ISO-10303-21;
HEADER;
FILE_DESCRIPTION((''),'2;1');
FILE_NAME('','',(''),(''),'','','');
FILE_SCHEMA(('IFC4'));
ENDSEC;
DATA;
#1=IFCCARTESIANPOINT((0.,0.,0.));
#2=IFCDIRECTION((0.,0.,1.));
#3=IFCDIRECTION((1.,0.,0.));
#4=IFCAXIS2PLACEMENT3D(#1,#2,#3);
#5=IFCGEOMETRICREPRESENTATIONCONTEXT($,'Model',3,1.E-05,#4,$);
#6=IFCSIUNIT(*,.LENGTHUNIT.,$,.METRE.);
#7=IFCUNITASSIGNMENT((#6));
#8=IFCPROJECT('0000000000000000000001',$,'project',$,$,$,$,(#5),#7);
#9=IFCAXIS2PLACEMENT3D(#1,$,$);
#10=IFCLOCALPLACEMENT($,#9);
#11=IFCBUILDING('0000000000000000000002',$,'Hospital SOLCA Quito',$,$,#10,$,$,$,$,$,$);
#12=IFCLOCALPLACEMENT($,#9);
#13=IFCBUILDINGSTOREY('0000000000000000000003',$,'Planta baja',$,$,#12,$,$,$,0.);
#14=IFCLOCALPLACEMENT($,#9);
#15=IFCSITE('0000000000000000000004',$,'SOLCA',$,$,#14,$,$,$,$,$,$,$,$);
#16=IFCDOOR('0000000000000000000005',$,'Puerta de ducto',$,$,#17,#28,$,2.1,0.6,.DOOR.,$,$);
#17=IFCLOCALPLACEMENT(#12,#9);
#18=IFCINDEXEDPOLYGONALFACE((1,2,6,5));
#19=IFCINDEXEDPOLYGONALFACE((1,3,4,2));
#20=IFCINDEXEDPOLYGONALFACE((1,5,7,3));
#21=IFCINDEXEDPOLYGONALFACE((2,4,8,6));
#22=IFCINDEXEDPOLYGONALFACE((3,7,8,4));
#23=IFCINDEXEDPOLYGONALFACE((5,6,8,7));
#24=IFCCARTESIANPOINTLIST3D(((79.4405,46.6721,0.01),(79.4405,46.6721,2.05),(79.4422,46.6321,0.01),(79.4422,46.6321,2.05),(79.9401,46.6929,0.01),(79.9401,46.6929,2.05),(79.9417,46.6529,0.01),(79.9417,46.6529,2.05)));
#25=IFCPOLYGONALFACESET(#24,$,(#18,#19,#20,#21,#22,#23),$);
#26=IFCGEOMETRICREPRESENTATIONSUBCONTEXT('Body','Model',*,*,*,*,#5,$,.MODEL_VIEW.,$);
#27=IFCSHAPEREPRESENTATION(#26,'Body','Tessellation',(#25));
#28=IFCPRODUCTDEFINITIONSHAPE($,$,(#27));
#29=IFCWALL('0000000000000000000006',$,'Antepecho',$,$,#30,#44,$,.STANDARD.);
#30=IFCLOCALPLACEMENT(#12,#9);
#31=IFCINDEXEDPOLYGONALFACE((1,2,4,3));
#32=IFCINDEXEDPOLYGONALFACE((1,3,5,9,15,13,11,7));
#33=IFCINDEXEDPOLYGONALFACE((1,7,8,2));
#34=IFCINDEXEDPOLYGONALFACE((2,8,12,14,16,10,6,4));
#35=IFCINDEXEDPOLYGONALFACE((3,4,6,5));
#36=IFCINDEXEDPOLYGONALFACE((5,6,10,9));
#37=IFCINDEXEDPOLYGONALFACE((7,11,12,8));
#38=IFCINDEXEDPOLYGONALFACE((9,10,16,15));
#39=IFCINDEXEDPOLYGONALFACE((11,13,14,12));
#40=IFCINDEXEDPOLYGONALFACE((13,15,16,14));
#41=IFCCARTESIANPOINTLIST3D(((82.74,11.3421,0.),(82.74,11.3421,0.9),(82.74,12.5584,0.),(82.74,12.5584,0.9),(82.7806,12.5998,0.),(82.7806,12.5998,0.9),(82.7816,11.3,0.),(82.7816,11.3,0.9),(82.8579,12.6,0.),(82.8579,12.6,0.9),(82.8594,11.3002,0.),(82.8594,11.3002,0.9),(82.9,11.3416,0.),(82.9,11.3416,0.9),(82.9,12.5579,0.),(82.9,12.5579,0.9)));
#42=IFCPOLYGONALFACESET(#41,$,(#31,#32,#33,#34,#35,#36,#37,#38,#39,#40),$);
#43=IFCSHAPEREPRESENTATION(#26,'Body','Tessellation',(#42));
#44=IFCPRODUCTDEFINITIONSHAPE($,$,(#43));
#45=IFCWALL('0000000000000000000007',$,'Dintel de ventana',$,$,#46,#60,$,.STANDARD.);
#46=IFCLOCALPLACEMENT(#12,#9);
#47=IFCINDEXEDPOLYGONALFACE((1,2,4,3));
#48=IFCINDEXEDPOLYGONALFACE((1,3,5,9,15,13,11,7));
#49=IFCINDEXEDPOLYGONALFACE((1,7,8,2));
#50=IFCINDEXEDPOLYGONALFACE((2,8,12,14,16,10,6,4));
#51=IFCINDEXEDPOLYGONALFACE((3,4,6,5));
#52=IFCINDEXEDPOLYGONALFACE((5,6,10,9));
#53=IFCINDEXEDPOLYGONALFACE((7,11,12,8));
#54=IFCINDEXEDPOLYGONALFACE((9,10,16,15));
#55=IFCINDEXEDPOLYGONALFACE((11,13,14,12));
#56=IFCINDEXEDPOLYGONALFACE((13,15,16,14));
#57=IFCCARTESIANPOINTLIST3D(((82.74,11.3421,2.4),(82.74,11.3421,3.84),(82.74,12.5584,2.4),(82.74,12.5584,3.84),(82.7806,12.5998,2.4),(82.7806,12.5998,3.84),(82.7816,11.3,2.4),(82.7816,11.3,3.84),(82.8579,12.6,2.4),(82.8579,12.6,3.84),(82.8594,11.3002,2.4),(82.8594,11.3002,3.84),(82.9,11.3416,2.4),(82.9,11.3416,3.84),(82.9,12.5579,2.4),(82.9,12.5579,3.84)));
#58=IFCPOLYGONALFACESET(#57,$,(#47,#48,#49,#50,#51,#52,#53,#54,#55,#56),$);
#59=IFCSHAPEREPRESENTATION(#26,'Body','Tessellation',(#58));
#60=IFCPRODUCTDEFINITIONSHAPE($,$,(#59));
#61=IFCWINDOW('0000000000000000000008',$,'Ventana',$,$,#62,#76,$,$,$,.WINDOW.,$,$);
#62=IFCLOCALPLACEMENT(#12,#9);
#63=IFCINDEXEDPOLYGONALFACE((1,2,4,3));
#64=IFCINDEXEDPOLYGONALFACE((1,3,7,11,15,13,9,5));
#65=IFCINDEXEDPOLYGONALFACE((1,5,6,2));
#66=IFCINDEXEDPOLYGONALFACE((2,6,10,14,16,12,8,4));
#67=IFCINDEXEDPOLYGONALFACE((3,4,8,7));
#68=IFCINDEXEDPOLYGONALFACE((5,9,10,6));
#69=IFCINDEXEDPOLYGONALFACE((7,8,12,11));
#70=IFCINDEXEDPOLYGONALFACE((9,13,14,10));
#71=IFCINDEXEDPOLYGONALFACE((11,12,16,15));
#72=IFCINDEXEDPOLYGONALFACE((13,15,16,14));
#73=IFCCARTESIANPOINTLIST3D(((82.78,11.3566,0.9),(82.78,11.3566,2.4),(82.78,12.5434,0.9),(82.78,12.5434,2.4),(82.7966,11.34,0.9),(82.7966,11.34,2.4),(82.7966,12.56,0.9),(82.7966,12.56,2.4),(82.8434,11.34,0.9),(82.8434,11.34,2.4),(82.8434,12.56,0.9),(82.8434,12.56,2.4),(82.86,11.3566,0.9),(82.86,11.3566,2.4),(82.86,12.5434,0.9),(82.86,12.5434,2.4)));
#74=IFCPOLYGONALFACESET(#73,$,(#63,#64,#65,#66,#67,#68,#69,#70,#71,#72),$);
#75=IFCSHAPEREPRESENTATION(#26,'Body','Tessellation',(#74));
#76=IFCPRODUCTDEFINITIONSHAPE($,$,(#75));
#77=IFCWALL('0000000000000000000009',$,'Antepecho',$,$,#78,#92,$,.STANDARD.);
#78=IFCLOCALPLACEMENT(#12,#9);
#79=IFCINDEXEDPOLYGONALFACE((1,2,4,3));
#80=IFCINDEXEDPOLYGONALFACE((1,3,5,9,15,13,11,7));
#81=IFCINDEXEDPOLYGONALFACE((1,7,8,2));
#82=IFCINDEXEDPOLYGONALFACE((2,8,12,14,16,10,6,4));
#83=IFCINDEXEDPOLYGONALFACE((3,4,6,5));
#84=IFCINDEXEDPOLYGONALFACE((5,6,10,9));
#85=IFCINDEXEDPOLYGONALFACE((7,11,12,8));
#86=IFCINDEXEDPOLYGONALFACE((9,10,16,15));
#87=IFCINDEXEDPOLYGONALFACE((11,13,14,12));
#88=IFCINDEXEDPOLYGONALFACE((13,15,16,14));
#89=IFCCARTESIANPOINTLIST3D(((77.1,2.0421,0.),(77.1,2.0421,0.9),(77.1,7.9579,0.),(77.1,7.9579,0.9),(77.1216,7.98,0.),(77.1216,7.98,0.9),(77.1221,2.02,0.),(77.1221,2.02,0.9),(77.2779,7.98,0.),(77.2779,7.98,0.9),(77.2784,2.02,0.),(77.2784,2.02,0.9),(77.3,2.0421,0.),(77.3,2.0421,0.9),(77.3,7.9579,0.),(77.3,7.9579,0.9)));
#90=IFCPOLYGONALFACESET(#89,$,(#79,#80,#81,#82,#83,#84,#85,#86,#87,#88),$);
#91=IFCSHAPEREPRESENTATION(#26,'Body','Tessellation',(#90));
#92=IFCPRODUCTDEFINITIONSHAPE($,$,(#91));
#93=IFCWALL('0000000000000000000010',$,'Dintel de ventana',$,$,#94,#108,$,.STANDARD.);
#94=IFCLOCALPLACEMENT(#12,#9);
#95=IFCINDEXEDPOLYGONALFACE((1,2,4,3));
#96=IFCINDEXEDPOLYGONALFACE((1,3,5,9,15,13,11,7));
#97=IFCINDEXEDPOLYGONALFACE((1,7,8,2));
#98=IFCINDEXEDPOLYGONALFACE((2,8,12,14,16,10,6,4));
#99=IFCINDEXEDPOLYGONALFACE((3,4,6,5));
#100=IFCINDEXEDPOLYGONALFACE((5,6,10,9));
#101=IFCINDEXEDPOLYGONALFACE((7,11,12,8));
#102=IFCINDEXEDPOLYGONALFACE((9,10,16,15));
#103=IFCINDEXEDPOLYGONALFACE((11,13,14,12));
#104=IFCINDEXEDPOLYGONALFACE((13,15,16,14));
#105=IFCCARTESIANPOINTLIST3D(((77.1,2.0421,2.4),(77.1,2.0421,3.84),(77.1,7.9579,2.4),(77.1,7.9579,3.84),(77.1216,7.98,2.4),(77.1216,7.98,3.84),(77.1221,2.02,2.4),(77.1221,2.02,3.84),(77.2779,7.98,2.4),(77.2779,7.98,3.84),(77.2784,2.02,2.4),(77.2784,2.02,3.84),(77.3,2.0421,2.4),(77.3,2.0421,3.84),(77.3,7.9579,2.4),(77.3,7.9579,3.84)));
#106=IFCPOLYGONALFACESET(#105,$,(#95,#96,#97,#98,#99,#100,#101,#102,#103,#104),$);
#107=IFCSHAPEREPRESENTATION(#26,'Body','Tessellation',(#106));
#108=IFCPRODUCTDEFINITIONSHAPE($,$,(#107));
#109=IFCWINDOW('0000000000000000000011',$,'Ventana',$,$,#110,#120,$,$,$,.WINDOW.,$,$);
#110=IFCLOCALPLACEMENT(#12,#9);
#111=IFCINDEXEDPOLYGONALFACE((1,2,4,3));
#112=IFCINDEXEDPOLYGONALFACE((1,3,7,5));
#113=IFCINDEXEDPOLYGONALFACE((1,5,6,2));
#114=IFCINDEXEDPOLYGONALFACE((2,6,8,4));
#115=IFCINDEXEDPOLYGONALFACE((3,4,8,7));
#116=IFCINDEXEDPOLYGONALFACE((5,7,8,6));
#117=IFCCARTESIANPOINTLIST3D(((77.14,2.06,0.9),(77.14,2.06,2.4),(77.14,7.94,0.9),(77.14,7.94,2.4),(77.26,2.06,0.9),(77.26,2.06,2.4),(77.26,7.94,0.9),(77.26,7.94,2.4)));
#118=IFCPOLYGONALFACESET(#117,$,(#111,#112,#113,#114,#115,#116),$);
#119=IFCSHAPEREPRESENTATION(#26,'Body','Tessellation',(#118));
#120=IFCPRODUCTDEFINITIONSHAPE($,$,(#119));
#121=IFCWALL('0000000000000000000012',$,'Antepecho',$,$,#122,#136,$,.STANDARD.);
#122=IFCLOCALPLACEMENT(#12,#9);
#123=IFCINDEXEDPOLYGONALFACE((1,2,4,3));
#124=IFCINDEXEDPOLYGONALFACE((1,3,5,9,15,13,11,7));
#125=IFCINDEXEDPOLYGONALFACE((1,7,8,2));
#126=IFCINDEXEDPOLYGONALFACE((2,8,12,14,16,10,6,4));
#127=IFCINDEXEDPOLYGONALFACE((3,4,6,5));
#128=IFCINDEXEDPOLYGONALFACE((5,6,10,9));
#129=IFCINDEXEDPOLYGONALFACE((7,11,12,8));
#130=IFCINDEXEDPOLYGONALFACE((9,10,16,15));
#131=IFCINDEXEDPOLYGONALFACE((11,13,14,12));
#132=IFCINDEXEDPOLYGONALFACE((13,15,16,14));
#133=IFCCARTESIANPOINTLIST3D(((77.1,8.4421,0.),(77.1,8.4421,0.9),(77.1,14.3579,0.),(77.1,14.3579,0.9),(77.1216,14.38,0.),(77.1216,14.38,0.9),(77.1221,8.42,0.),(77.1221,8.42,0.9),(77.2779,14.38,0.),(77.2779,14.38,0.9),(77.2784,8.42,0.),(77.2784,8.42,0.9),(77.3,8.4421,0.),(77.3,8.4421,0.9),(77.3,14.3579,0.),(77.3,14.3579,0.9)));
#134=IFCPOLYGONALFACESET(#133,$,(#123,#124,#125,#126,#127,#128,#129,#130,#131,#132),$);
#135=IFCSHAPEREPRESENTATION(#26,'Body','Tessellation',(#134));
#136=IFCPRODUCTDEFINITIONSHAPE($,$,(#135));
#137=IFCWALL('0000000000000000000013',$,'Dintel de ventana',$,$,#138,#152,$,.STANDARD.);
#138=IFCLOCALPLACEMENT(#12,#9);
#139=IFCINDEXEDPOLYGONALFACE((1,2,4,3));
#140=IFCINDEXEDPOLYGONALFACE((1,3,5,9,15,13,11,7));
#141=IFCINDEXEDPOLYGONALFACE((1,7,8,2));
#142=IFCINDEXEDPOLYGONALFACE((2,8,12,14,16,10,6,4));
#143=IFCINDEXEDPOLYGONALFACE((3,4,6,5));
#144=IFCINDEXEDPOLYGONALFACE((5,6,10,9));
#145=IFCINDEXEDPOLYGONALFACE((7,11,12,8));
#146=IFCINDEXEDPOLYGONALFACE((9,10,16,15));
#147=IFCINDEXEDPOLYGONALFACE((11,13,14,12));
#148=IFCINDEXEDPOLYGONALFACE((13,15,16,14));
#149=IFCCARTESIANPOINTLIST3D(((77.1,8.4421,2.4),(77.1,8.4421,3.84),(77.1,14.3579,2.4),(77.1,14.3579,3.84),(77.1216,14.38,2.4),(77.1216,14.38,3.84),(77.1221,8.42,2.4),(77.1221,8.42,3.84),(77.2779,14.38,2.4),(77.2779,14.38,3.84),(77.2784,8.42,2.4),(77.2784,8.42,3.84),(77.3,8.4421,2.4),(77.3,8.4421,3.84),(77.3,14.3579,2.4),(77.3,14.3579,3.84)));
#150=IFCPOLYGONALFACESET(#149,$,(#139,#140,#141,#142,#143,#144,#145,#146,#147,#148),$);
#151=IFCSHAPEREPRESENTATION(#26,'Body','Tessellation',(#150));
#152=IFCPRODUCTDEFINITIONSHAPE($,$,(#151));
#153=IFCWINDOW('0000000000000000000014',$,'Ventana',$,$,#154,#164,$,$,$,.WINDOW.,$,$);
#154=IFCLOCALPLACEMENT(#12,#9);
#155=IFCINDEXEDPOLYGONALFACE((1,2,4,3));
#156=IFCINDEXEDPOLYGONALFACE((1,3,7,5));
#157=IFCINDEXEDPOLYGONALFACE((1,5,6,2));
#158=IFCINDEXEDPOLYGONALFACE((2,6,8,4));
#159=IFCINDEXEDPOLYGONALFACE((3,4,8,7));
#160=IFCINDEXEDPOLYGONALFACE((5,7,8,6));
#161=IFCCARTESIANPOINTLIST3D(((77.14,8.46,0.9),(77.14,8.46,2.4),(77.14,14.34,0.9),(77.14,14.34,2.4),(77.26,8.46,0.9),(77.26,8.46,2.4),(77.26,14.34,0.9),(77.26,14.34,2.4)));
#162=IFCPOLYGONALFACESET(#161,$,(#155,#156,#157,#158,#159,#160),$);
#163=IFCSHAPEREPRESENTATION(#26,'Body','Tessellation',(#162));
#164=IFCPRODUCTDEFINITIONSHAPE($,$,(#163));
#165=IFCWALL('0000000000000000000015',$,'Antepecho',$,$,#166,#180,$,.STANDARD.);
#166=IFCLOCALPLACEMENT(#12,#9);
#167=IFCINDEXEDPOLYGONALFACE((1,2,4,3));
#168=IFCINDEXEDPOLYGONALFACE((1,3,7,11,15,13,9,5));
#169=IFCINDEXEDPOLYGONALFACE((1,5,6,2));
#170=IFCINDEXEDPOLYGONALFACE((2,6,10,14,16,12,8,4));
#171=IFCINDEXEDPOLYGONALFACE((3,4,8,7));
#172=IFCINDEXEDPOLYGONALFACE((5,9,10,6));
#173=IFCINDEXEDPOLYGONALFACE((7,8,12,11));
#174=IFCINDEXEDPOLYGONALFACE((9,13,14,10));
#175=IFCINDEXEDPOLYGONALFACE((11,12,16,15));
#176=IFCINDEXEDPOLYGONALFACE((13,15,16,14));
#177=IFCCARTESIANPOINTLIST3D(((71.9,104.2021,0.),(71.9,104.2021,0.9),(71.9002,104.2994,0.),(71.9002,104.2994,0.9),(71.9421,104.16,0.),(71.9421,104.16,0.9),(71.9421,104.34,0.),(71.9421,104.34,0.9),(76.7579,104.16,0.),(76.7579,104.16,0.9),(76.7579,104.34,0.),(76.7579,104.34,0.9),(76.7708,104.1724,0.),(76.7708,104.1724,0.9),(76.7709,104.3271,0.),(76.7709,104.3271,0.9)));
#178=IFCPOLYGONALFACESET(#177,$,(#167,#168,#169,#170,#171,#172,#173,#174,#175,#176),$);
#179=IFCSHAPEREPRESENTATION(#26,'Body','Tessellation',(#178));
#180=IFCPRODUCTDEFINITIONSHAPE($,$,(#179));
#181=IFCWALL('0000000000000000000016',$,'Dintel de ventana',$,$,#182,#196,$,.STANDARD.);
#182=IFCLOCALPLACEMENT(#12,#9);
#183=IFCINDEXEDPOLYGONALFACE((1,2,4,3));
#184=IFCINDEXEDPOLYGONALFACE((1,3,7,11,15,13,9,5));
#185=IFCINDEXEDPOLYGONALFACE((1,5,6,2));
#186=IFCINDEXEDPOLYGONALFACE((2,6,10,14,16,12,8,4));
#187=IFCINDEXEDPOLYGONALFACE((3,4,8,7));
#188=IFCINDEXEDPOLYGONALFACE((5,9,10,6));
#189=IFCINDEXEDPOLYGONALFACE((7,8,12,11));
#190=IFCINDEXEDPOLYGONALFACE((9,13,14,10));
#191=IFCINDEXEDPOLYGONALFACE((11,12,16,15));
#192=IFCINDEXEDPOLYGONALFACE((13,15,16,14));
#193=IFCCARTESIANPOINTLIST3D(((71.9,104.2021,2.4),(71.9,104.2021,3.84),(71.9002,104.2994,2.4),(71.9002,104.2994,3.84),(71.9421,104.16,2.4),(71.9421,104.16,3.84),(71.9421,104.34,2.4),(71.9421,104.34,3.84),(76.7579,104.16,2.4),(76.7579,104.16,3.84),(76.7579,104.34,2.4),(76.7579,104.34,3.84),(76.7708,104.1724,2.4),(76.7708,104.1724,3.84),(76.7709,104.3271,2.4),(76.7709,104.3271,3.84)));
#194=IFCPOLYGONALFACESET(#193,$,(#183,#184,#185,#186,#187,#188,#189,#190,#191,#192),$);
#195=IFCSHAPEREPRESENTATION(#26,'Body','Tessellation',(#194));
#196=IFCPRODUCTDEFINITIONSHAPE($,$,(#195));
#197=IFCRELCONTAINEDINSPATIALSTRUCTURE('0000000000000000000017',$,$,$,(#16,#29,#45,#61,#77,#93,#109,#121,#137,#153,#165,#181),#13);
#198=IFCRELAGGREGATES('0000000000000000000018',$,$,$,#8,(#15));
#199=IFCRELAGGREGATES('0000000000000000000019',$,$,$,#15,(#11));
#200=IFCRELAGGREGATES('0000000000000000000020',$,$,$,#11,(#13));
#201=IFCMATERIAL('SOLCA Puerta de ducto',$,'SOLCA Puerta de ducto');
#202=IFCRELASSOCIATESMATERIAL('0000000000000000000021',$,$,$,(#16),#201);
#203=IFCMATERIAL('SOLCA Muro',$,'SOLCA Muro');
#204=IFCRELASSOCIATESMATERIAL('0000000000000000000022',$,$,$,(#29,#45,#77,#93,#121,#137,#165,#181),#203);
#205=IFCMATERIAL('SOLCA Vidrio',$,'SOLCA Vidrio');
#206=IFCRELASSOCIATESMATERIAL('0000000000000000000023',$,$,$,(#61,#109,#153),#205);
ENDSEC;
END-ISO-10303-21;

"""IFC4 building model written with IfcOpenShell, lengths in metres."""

from ifc_helpers import new_model, si_unit, frame, origin, origin_with_axes, place, context, subcontext, project, spatial, polyline, outline, extrude, material, element, save


model = new_model("IFC4")

# Units and contexts
model_context = context("Model", 3, precision=1e-05, world=origin_with_axes())
body_context = subcontext(model_context, "Body", "Model", "MODEL_VIEW")
ifc_project = project(units=[si_unit("LENGTHUNIT", "METRE")], contexts=[model_context])

# Site, building, storey
site_placement = place(None, origin())
site = spatial("IfcSite", under=ifc_project, at=site_placement, Name="SOLCA")
building_placement = place(None, origin())
building = spatial("IfcBuilding", under=site, at=building_placement, Name="Hospital SOLCA Quito")
storey_placement = place(None, origin())
storey = spatial("IfcBuildingStorey", under=building, at=storey_placement, Name="Planta baja", Elevation=0.0)

# Shared definitions
ifc_material_1 = material(Name="SOLCA Muro", Category="SOLCA Muro")

# Shared definitions
ifc_material_2 = material(Name="SOLCA Puerta de ducto", Category="SOLCA Puerta de ducto")

# Door
door_1_placement = place(storey_placement, origin_with_axes())
element("IfcDoor", 1, at=door_1_placement, inside=storey, material=ifc_material_2, Name="Puerta de ducto", OverallHeight=2.1, OverallWidth=0.6, PredefinedType="DOOR", context=body_context, shape_type="SweptSolid", body=[
    extrude(outline(polyline([(79.4422, 46.6321), (79.9417, 46.6529), (79.9401, 46.6929), (79.4405, 46.6721), (79.4422, 46.6321)])), frame((0.0, 0.0, 0.01), z_axis=(0.0, 0.0, 1.0), x_axis=(1.0, 0.0, 0.0)), (0.0, 0.0, 1.0), 2.04),
])

# Walls
wall_1_placement = place(storey_placement, origin_with_axes())
element("IfcWall", 2, at=wall_1_placement, inside=storey, material=ifc_material_1, Name="Antepecho", PredefinedType="STANDARD", context=body_context, shape_type="SweptSolid", body=[
    extrude(outline(polyline([(82.8579, 12.6), (82.9, 12.5579), (82.9, 11.3416), (82.8594, 11.3002), (82.7816, 11.3), (82.74, 11.3421), (82.74, 12.5584), (82.7806, 12.5998), (82.8579, 12.6)])), origin_with_axes(), (0.0, 0.0, 1.0), 0.9),
])
wall_2_placement = place(storey_placement, origin_with_axes())
element("IfcWall", 3, at=wall_2_placement, inside=storey, material=ifc_material_1, Name="Dintel de ventana", PredefinedType="STANDARD", context=body_context, shape_type="SweptSolid", body=[
    extrude(outline(polyline([(82.8579, 12.6), (82.9, 12.5579), (82.9, 11.3416), (82.8594, 11.3002), (82.7816, 11.3), (82.74, 11.3421), (82.74, 12.5584), (82.7806, 12.5998), (82.8579, 12.6)])), frame((0.0, 0.0, 2.4), z_axis=(0.0, 0.0, 1.0), x_axis=(1.0, 0.0, 0.0)), (0.0, 0.0, 1.0), 1.44),
])

# Window
ifc_material_3 = material(Name="SOLCA Vidrio", Category="SOLCA Vidrio")
window_1_placement = place(storey_placement, origin_with_axes())
element("IfcWindow", 4, at=window_1_placement, inside=storey, material=ifc_material_3, Name="Ventana", PredefinedType="WINDOW", context=body_context, shape_type="SweptSolid", body=[
    extrude(outline(polyline([(82.78, 11.3566), (82.78, 12.5434), (82.7966, 12.56), (82.8434, 12.56), (82.86, 12.5434), (82.86, 11.3566), (82.8434, 11.34), (82.7966, 11.34), (82.78, 11.3566)])), frame((0.0, 0.0, 0.9), z_axis=(0.0, 0.0, 1.0), x_axis=(1.0, 0.0, 0.0)), (0.0, 0.0, 1.0), 1.5),
])

# Walls
wall_3_placement = place(storey_placement, origin_with_axes())
element("IfcWall", 5, at=wall_3_placement, inside=storey, material=ifc_material_1, Name="Antepecho", PredefinedType="STANDARD", context=body_context, shape_type="SweptSolid", body=[
    extrude(outline(polyline([(77.2779, 7.98), (77.3, 7.9579), (77.3, 2.0421), (77.2784, 2.02), (77.1221, 2.02), (77.1, 2.0421), (77.1, 7.9579), (77.1216, 7.98), (77.2779, 7.98)])), origin_with_axes(), (0.0, 0.0, 1.0), 0.9),
])
wall_4_placement = place(storey_placement, origin_with_axes())
element("IfcWall", 6, at=wall_4_placement, inside=storey, material=ifc_material_1, Name="Dintel de ventana", PredefinedType="STANDARD", context=body_context, shape_type="SweptSolid", body=[
    extrude(outline(polyline([(77.2779, 7.98), (77.3, 7.9579), (77.3, 2.0421), (77.2784, 2.02), (77.1221, 2.02), (77.1, 2.0421), (77.1, 7.9579), (77.1216, 7.98), (77.2779, 7.98)])), frame((0.0, 0.0, 2.4), z_axis=(0.0, 0.0, 1.0), x_axis=(1.0, 0.0, 0.0)), (0.0, 0.0, 1.0), 1.44),
])

# Window
window_2_placement = place(storey_placement, origin_with_axes())
element("IfcWindow", 7, at=window_2_placement, inside=storey, material=ifc_material_3, Name="Ventana", PredefinedType="WINDOW", context=body_context, shape_type="SweptSolid", body=[
    extrude(outline(polyline([(77.14, 2.06), (77.14, 7.94), (77.26, 7.94), (77.26, 2.06), (77.14, 2.06)])), frame((0.0, 0.0, 0.9), z_axis=(0.0, 0.0, 1.0), x_axis=(1.0, 0.0, 0.0)), (0.0, 0.0, 1.0), 1.5),
])

# Walls
wall_5_placement = place(storey_placement, origin_with_axes())
element("IfcWall", 8, at=wall_5_placement, inside=storey, material=ifc_material_1, Name="Antepecho", PredefinedType="STANDARD", context=body_context, shape_type="SweptSolid", body=[
    extrude(outline(polyline([(77.2779, 14.38), (77.3, 14.3579), (77.3, 8.4421), (77.2784, 8.42), (77.1221, 8.42), (77.1, 8.4421), (77.1, 14.3579), (77.1216, 14.38), (77.2779, 14.38)])), origin_with_axes(), (0.0, 0.0, 1.0), 0.9),
])
wall_6_placement = place(storey_placement, origin_with_axes())
element("IfcWall", 9, at=wall_6_placement, inside=storey, material=ifc_material_1, Name="Dintel de ventana", PredefinedType="STANDARD", context=body_context, shape_type="SweptSolid", body=[
    extrude(outline(polyline([(77.2779, 14.38), (77.3, 14.3579), (77.3, 8.4421), (77.2784, 8.42), (77.1221, 8.42), (77.1, 8.4421), (77.1, 14.3579), (77.1216, 14.38), (77.2779, 14.38)])), frame((0.0, 0.0, 2.4), z_axis=(0.0, 0.0, 1.0), x_axis=(1.0, 0.0, 0.0)), (0.0, 0.0, 1.0), 1.44),
])

# Window
window_3_placement = place(storey_placement, origin_with_axes())
element("IfcWindow", 10, at=window_3_placement, inside=storey, material=ifc_material_3, Name="Ventana", PredefinedType="WINDOW", context=body_context, shape_type="SweptSolid", body=[
    extrude(outline(polyline([(77.14, 8.46), (77.14, 14.34), (77.26, 14.34), (77.26, 8.46), (77.14, 8.46)])), frame((0.0, 0.0, 0.9), z_axis=(0.0, 0.0, 1.0), x_axis=(1.0, 0.0, 0.0)), (0.0, 0.0, 1.0), 1.5),
])

# Walls
wall_7_placement = place(storey_placement, origin_with_axes())
element("IfcWall", 11, at=wall_7_placement, inside=storey, material=ifc_material_1, Name="Antepecho", PredefinedType="STANDARD", context=body_context, shape_type="SweptSolid", body=[
    extrude(outline(polyline([(76.7579, 104.34), (76.7709, 104.3271), (76.7708, 104.1724), (76.7579, 104.16), (71.9421, 104.16), (71.9, 104.2021), (71.9002, 104.2994), (71.9421, 104.34), (76.7579, 104.34)])), origin_with_axes(), (0.0, 0.0, 1.0), 0.9),
])
wall_8_placement = place(storey_placement, origin_with_axes())
element("IfcWall", 12, at=wall_8_placement, inside=storey, material=ifc_material_1, Name="Dintel de ventana", PredefinedType="STANDARD", context=body_context, shape_type="SweptSolid", body=[
    extrude(outline(polyline([(76.7579, 104.34), (76.7709, 104.3271), (76.7708, 104.1724), (76.7579, 104.16), (71.9421, 104.16), (71.9, 104.2021), (71.9002, 104.2994), (71.9421, 104.34), (76.7579, 104.34)])), frame((0.0, 0.0, 2.4), z_axis=(0.0, 0.0, 1.0), x_axis=(1.0, 0.0, 0.0)), (0.0, 0.0, 1.0), 1.44),
])

save(model, "model.ifc")
